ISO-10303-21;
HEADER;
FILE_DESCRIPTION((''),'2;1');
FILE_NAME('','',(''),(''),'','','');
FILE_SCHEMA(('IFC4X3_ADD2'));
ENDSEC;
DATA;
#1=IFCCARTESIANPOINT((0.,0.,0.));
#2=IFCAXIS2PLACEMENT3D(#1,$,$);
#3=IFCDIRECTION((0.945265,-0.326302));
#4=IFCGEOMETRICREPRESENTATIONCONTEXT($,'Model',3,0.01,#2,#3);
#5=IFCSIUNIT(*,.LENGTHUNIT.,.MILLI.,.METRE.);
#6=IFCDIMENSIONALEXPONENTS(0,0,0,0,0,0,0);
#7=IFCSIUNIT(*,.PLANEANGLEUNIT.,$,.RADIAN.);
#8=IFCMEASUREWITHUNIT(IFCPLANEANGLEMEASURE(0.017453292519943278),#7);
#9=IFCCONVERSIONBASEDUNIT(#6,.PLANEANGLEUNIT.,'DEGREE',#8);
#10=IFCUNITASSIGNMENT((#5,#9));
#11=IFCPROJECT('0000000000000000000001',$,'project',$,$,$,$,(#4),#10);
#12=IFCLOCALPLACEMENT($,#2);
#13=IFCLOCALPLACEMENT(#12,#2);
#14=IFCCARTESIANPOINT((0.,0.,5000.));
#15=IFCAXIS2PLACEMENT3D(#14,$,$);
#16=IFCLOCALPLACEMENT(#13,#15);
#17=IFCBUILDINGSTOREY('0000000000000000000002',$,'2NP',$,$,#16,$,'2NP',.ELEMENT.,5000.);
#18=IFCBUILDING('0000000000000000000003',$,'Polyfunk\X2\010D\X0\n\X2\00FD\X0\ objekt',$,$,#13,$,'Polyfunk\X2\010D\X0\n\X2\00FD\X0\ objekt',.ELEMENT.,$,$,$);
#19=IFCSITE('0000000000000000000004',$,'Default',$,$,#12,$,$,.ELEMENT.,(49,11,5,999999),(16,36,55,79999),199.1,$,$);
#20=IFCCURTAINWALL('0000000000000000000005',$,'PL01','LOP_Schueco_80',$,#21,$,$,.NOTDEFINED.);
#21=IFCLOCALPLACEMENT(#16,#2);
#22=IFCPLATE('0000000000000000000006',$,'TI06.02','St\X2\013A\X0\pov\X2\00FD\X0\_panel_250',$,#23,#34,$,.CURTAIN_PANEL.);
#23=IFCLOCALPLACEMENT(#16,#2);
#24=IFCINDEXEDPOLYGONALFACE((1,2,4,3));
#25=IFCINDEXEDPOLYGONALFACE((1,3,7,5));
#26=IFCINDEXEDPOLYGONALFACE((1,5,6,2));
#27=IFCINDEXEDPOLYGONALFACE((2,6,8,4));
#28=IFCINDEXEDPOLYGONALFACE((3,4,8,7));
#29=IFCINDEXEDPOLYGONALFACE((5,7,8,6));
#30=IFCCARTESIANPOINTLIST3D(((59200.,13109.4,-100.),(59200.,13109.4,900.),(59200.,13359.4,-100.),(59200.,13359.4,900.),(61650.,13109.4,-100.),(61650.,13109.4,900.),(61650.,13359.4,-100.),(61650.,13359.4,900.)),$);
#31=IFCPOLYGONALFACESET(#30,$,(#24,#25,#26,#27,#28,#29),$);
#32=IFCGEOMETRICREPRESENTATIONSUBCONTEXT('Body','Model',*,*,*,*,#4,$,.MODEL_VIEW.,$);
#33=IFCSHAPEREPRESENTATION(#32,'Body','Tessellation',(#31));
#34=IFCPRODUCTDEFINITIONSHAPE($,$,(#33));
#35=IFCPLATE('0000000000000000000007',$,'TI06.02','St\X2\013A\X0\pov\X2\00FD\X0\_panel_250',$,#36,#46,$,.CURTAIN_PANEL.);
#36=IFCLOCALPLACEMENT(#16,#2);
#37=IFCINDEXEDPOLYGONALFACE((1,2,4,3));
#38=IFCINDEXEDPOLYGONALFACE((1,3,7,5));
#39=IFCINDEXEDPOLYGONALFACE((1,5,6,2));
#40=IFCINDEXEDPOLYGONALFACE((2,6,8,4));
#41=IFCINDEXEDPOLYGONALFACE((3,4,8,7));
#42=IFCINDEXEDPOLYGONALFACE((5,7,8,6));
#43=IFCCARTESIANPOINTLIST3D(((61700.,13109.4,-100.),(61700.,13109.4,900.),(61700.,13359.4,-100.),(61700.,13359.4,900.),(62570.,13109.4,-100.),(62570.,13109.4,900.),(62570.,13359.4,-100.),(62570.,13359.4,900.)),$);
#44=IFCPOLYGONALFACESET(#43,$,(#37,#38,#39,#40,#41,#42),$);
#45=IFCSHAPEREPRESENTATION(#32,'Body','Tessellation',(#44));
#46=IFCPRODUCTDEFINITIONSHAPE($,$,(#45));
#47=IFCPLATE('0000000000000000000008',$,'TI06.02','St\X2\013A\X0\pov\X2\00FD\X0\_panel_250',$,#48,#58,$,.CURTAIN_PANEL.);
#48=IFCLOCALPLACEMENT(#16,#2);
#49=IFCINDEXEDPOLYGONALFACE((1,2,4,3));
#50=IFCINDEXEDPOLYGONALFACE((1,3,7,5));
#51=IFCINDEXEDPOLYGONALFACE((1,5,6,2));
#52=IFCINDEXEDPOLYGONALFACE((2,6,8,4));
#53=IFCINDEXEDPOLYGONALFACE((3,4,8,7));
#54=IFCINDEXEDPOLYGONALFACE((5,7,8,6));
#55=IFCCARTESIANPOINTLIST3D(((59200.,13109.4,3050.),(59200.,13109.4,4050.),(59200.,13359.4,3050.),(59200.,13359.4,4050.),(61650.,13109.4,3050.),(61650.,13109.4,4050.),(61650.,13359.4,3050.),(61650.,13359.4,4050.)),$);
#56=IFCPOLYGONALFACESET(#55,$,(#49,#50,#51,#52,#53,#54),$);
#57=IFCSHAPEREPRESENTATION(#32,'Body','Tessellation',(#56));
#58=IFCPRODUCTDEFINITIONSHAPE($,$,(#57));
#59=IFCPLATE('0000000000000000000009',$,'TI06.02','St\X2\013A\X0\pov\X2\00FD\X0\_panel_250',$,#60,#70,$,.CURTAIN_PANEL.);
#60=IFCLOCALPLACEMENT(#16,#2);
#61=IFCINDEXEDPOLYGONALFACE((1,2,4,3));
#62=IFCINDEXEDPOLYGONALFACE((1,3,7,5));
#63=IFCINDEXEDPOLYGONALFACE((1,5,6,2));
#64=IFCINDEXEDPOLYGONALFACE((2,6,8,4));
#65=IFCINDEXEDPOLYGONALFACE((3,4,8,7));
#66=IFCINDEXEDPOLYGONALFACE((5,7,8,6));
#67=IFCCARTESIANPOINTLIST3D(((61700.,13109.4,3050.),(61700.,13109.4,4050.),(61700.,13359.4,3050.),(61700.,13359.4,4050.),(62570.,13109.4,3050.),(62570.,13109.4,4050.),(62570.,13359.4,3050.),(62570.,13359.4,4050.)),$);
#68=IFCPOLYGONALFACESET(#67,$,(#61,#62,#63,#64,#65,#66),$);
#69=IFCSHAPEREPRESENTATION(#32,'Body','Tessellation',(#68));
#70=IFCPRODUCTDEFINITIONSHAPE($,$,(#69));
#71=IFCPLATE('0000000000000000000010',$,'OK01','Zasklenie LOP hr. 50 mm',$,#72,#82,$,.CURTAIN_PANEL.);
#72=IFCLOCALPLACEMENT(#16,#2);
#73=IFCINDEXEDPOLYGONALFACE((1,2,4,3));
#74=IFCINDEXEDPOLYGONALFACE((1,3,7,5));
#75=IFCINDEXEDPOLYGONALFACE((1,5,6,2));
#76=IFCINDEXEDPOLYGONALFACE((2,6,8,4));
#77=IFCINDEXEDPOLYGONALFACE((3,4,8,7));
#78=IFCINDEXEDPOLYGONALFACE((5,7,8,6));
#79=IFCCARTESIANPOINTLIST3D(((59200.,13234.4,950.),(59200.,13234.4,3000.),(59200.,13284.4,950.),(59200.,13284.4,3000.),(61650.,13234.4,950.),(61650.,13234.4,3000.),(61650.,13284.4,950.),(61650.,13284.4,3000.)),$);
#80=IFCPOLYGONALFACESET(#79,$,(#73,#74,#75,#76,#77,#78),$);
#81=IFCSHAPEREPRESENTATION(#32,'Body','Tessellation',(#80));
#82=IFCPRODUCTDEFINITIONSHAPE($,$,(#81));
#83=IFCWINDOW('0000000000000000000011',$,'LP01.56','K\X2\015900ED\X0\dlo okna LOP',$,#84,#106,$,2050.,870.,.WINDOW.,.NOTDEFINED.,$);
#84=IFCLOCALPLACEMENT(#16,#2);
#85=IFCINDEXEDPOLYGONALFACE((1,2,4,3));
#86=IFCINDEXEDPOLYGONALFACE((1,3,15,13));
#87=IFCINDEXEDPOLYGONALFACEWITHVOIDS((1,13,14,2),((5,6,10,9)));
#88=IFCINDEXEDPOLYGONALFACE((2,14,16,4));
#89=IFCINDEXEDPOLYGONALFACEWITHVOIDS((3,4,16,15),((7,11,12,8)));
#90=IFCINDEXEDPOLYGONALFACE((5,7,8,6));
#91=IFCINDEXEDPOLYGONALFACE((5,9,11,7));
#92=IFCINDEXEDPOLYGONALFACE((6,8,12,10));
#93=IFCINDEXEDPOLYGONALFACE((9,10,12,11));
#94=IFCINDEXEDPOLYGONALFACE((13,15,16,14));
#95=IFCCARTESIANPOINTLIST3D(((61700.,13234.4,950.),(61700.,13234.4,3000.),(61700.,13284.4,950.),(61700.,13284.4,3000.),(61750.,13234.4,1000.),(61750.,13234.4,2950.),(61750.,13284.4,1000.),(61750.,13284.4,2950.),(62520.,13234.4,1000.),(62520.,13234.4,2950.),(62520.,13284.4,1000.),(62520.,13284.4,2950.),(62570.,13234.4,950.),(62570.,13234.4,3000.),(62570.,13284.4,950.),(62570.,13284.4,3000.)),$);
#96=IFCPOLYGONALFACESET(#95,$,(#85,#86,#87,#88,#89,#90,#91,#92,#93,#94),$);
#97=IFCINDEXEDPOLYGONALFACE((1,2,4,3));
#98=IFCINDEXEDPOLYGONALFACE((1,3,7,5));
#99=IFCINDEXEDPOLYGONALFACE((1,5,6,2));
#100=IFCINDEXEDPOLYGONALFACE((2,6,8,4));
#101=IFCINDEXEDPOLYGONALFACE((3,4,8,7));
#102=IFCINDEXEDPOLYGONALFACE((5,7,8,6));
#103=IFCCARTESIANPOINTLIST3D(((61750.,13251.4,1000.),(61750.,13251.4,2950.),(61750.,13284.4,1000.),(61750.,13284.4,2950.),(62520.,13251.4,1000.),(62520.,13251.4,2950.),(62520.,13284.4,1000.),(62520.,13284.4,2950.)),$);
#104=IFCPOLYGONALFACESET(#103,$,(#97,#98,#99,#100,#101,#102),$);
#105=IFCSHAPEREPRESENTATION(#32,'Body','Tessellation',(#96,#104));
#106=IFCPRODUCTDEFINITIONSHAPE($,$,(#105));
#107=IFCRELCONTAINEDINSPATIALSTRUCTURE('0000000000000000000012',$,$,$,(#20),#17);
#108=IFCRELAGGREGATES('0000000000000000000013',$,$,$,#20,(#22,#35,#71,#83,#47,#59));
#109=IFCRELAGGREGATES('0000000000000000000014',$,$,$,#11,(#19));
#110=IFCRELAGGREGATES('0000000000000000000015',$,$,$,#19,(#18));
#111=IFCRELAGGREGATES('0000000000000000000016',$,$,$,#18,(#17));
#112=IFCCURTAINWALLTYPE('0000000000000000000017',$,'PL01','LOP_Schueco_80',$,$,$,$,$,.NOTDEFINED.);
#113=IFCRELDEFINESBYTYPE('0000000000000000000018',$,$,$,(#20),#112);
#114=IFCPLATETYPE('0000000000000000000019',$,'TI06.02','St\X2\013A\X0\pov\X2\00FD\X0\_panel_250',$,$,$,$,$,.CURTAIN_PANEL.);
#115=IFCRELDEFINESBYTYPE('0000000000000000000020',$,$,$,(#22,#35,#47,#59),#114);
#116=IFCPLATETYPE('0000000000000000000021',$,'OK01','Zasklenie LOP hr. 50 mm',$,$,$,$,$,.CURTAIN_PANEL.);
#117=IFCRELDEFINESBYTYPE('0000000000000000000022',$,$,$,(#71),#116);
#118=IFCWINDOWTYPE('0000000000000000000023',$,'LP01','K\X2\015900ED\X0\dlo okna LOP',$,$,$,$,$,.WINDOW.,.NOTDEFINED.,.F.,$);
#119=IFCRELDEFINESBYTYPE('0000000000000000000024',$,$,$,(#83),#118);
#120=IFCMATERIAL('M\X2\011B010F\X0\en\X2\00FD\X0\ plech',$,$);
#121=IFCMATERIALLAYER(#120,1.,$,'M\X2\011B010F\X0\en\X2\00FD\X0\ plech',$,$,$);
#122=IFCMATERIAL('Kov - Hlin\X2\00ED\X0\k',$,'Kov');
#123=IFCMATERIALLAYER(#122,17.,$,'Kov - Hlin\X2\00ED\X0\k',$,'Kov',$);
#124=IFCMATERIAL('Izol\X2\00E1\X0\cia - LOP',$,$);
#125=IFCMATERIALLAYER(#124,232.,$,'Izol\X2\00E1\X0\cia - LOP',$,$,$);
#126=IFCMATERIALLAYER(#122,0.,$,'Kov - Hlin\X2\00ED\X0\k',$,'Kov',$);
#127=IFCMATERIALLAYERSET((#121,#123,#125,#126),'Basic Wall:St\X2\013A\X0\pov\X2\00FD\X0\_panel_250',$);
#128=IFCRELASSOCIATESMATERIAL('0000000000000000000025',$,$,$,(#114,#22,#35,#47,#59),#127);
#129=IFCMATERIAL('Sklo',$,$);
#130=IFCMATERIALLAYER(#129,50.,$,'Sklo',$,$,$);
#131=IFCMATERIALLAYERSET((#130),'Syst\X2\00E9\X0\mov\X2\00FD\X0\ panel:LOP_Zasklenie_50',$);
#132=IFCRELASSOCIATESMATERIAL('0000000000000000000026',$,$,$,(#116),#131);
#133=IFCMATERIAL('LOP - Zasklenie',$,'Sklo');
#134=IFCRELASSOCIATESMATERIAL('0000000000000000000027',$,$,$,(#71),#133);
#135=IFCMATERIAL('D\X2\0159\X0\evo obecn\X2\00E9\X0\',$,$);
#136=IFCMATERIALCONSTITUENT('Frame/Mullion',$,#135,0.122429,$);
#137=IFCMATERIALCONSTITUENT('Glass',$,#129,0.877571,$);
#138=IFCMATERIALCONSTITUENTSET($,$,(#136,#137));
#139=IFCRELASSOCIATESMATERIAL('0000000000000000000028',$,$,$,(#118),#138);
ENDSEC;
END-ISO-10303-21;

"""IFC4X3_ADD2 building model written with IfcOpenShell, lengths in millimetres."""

from ifc_helpers import new_model, entity, si_unit, converted_unit, direction, frame, frame_2d, origin, origin_2d_with_axis, place, context, subcontext, project, spatial, polyline, rectangle, outline, extrude, source, transform, mapped, material, layer, layer_set, layer_usage, constituent, constituent_set, type_object, type_shapes, element, aggregate, save


model = new_model("IFC4X3_ADD2")

# Units and contexts
model_context = context("Model", 3, precision=0.01, world=origin(), true_north=direction((0.945265, -0.326302)))
body_context = subcontext(model_context, "Body", "Model", "MODEL_VIEW")
ifc_project = project(units=[si_unit("LENGTHUNIT", "METRE", prefix="MILLI"), converted_unit("PLANEANGLEUNIT", "DEGREE", entity("IfcPlaneAngleMeasure", 0.017453292519943278), si_unit("PLANEANGLEUNIT", "RADIAN"), dimensions=[0, 0, 0, 0, 0, 0, 0])], contexts=[model_context])

# Site, building, storey
site_placement = place(None, origin())
site = spatial("IfcSite", under=ifc_project, at=site_placement, Name="Default", CompositionType="ELEMENT", RefLatitude=(49, 11, 5, 999999), RefLongitude=(16, 36, 55, 79999), RefElevation=199.1)
building_placement = place(site_placement, origin())
building = spatial("IfcBuilding", under=site, at=building_placement, Name="Polyfunkčný objekt", LongName="Polyfunkčný objekt", CompositionType="ELEMENT")
storey_placement = place(building_placement, frame((0.0, 0.0, 5000.0)))
storey = spatial("IfcBuildingStorey", under=building, at=storey_placement, Name="2NP", LongName="2NP", CompositionType="ELEMENT", Elevation=5000.0)

# Curtain wall, plates, window
curtain_wall_type = type_object("IfcCurtainWallType", Name="PL01", Description="LOP_Schueco_80", PredefinedType="NOTDEFINED")
curtain_wall_placement = place(storey_placement, frame((0.0, 0.0, -5000.0)))
curtain_wall = element("IfcCurtainWall", 1, at=curtain_wall_placement, inside=storey, type_object=curtain_wall_type, Name="PL01", Description="LOP_Schueco_80", PredefinedType="NOTDEFINED")
ifc_material_1 = material(Name="Měďený plech")
ifc_layer_1 = layer(ifc_material_1, 1.0, Name="Měďený plech")
ifc_material_2 = material(Name="Kov - Hliník", Category="Kov")
ifc_layer_2 = layer(ifc_material_2, 17.0, Name="Kov - Hliník", Category="Kov")
ifc_material_3 = material(Name="Izolácia - LOP")
ifc_layer_3 = layer(ifc_material_3, 232.0, Name="Izolácia - LOP")
ifc_layer_4 = layer(ifc_material_2, 0.0, Name="Kov - Hliník", Category="Kov")
ifc_layer_set_1 = layer_set([ifc_layer_1, ifc_layer_2, ifc_layer_3, ifc_layer_4], Name="Basic Wall:Stĺpový_panel_250")
ifc_layer_usage_1 = layer_usage(ifc_layer_set_1, "AXIS2", "NEGATIVE", 125.0)
plate_type_1 = type_object("IfcPlateType", Name="TI06.02", Description="Stĺpový_panel_250", PredefinedType="CURTAIN_PANEL", material=ifc_layer_set_1)
plate_1_placement = place(storey_placement, frame((59200.0, 13234.4, -100.0)))
plate_1 = element("IfcPlate", 2, at=plate_1_placement, type_object=plate_type_1, material=ifc_layer_usage_1, Name="TI06.02", Description="Stĺpový_panel_250", PredefinedType="CURTAIN_PANEL", context=body_context, shape_type="SweptSolid", body=[
    extrude(rectangle(XDim=250.0, YDim=2450.0, at=frame_2d((0.0, 0.0), x_axis=(1.0, 0.0))), frame((1225.0, 0.0, 0.0), z_axis=(0.0, 0.0, 1.0), x_axis=(0.0, 1.0, 0.0)), (0.0, 0.0, 1.0), 1000.0),
])
ifc_layer_usage_2 = layer_usage(ifc_layer_set_1, "AXIS2", "NEGATIVE", 125.0)
plate_2_placement = place(storey_placement, frame((61700.0, 13234.4, -100.0)))
plate_2 = element("IfcPlate", 3, at=plate_2_placement, type_object=plate_type_1, material=ifc_layer_usage_2, Name="TI06.02", Description="Stĺpový_panel_250", PredefinedType="CURTAIN_PANEL", context=body_context, shape_type="SweptSolid", body=[
    extrude(rectangle(XDim=250.0, YDim=870.0, at=frame_2d((0.0, 0.0), x_axis=(1.0, 0.0))), frame((435.0, 0.0, 0.0), z_axis=(0.0, 0.0, 1.0), x_axis=(0.0, 1.0, 0.0)), (0.0, 0.0, 1.0), 1000.0),
])
ifc_layer_usage_3 = layer_usage(ifc_layer_set_1, "AXIS2", "NEGATIVE", 125.0)
plate_3_placement = place(storey_placement, frame((59200.0, 13234.4, 3050.0)))
plate_3 = element("IfcPlate", 4, at=plate_3_placement, type_object=plate_type_1, material=ifc_layer_usage_3, Name="TI06.02", Description="Stĺpový_panel_250", PredefinedType="CURTAIN_PANEL", context=body_context, shape_type="SweptSolid", body=[
    extrude(rectangle(XDim=250.0, YDim=2450.0, at=frame_2d((0.0, 0.0), x_axis=(1.0, 0.0))), frame((1225.0, 0.0, 0.0), z_axis=(0.0, 0.0, 1.0), x_axis=(0.0, 1.0, 0.0)), (0.0, 0.0, 1.0), 1000.0),
])
ifc_layer_usage_4 = layer_usage(ifc_layer_set_1, "AXIS2", "NEGATIVE", 125.0)
plate_4_placement = place(storey_placement, frame((61700.0, 13234.4, 3050.0)))
plate_4 = element("IfcPlate", 5, at=plate_4_placement, type_object=plate_type_1, material=ifc_layer_usage_4, Name="TI06.02", Description="Stĺpový_panel_250", PredefinedType="CURTAIN_PANEL", context=body_context, shape_type="SweptSolid", body=[
    extrude(rectangle(XDim=250.0, YDim=870.0, at=frame_2d((0.0, 0.0), x_axis=(1.0, 0.0))), frame((435.0, 0.0, 0.0), z_axis=(0.0, 0.0, 1.0), x_axis=(0.0, 1.0, 0.0)), (0.0, 0.0, 1.0), 1000.0),
])
ifc_material_4 = material(Name="LOP - Zasklenie", Category="Sklo")
ifc_material_5 = material(Name="Sklo")
ifc_layer_5 = layer(ifc_material_5, 50.0, Name="Sklo")
ifc_layer_set_2 = layer_set([ifc_layer_5], Name="Systémový panel:LOP_Zasklenie_50")
plate_type_2 = type_object("IfcPlateType", Name="OK01", Description="Zasklenie LOP hr. 50 mm", PredefinedType="CURTAIN_PANEL", material=ifc_layer_set_2)
shared_shape_1 = source(origin(), body_context, "Body", "SweptSolid", [
    extrude(rectangle(XDim=50.0, YDim=2450.0, at=origin_2d_with_axis()), frame((0.0, 25.0, 0.0), z_axis=(0.0, 0.0, 1.0), x_axis=(0.0, 1.0, 0.0)), (0.0, 0.0, 1.0), 2050.0),
])
type_shapes(plate_type_2, [shared_shape_1])
plate_5_placement = place(curtain_wall_placement, frame((60425.0, 13234.4, 5950.0)))
plate_5 = element("IfcPlate", 6, at=plate_5_placement, type_object=plate_type_2, material=ifc_material_4, Name="OK01", Description="Zasklenie LOP hr. 50 mm", PredefinedType="CURTAIN_PANEL", context=body_context, shape_type="MappedRepresentation", body=[
    mapped(shared_shape_1, transform((0.0, 0.0, 0.0), scale=1.0)),
])
ifc_material_6 = material(Name="Dřevo obecné")
ifc_constituent_1 = constituent(ifc_material_6, Name="Frame/Mullion", fraction=0.122429)
ifc_constituent_2 = constituent(ifc_material_5, Name="Glass", fraction=0.877571)
ifc_constituent_set = constituent_set(constituents=[ifc_constituent_1, ifc_constituent_2])
window_type = type_object("IfcWindowType", Name="LP01", Description="Křídlo okna LOP", ParameterTakesPrecedence=False, PartitioningType="NOTDEFINED", PredefinedType="WINDOW", material=ifc_constituent_set)
shared_shape_2 = source(origin(), body_context, "Body", "SweptSolid", [
    extrude(outline(polyline([(-1025.0, -435.0), (1025.0, -435.0), (1025.0, 435.0), (-1025.0, 435.0), (-1025.0, -435.0)]), holes=[polyline([(-975.0, -385.0), (-975.0, 385.0), (975.0, 385.0), (975.0, -385.0), (-975.0, -385.0)])]), frame((0.0, 0.0, 1025.0), z_axis=(0.0, 1.0, 0.0), x_axis=(0.0, 0.0, -1.0)), (0.0, 0.0, 1.0), 50.0),
    extrude(rectangle(XDim=33.0, YDim=770.0, at=origin_2d_with_axis()), frame((0.0, 33.5, 50.0), z_axis=(0.0, 0.0, 1.0), x_axis=(0.0, -1.0, 0.0)), (0.0, 0.0, 1.0), 1950.0),
])
type_shapes(window_type, [shared_shape_2])
window_placement = place(curtain_wall_placement, frame((62135.0, 13234.4, 5950.0)))
window = element("IfcWindow", 7, at=window_placement, type_object=window_type, Name="LP01.56", Description="Křídlo okna LOP", OverallHeight=2050.0, OverallWidth=870.0, PartitioningType="NOTDEFINED", PredefinedType="WINDOW", context=body_context, shape_type="MappedRepresentation", body=[
    mapped(shared_shape_2, transform((0.0, 0.0, 0.0), scale=1.0)),
])
aggregate(curtain_wall, [plate_1, plate_2, plate_5, window, plate_3, plate_4])

save(model, "model.ifc")
